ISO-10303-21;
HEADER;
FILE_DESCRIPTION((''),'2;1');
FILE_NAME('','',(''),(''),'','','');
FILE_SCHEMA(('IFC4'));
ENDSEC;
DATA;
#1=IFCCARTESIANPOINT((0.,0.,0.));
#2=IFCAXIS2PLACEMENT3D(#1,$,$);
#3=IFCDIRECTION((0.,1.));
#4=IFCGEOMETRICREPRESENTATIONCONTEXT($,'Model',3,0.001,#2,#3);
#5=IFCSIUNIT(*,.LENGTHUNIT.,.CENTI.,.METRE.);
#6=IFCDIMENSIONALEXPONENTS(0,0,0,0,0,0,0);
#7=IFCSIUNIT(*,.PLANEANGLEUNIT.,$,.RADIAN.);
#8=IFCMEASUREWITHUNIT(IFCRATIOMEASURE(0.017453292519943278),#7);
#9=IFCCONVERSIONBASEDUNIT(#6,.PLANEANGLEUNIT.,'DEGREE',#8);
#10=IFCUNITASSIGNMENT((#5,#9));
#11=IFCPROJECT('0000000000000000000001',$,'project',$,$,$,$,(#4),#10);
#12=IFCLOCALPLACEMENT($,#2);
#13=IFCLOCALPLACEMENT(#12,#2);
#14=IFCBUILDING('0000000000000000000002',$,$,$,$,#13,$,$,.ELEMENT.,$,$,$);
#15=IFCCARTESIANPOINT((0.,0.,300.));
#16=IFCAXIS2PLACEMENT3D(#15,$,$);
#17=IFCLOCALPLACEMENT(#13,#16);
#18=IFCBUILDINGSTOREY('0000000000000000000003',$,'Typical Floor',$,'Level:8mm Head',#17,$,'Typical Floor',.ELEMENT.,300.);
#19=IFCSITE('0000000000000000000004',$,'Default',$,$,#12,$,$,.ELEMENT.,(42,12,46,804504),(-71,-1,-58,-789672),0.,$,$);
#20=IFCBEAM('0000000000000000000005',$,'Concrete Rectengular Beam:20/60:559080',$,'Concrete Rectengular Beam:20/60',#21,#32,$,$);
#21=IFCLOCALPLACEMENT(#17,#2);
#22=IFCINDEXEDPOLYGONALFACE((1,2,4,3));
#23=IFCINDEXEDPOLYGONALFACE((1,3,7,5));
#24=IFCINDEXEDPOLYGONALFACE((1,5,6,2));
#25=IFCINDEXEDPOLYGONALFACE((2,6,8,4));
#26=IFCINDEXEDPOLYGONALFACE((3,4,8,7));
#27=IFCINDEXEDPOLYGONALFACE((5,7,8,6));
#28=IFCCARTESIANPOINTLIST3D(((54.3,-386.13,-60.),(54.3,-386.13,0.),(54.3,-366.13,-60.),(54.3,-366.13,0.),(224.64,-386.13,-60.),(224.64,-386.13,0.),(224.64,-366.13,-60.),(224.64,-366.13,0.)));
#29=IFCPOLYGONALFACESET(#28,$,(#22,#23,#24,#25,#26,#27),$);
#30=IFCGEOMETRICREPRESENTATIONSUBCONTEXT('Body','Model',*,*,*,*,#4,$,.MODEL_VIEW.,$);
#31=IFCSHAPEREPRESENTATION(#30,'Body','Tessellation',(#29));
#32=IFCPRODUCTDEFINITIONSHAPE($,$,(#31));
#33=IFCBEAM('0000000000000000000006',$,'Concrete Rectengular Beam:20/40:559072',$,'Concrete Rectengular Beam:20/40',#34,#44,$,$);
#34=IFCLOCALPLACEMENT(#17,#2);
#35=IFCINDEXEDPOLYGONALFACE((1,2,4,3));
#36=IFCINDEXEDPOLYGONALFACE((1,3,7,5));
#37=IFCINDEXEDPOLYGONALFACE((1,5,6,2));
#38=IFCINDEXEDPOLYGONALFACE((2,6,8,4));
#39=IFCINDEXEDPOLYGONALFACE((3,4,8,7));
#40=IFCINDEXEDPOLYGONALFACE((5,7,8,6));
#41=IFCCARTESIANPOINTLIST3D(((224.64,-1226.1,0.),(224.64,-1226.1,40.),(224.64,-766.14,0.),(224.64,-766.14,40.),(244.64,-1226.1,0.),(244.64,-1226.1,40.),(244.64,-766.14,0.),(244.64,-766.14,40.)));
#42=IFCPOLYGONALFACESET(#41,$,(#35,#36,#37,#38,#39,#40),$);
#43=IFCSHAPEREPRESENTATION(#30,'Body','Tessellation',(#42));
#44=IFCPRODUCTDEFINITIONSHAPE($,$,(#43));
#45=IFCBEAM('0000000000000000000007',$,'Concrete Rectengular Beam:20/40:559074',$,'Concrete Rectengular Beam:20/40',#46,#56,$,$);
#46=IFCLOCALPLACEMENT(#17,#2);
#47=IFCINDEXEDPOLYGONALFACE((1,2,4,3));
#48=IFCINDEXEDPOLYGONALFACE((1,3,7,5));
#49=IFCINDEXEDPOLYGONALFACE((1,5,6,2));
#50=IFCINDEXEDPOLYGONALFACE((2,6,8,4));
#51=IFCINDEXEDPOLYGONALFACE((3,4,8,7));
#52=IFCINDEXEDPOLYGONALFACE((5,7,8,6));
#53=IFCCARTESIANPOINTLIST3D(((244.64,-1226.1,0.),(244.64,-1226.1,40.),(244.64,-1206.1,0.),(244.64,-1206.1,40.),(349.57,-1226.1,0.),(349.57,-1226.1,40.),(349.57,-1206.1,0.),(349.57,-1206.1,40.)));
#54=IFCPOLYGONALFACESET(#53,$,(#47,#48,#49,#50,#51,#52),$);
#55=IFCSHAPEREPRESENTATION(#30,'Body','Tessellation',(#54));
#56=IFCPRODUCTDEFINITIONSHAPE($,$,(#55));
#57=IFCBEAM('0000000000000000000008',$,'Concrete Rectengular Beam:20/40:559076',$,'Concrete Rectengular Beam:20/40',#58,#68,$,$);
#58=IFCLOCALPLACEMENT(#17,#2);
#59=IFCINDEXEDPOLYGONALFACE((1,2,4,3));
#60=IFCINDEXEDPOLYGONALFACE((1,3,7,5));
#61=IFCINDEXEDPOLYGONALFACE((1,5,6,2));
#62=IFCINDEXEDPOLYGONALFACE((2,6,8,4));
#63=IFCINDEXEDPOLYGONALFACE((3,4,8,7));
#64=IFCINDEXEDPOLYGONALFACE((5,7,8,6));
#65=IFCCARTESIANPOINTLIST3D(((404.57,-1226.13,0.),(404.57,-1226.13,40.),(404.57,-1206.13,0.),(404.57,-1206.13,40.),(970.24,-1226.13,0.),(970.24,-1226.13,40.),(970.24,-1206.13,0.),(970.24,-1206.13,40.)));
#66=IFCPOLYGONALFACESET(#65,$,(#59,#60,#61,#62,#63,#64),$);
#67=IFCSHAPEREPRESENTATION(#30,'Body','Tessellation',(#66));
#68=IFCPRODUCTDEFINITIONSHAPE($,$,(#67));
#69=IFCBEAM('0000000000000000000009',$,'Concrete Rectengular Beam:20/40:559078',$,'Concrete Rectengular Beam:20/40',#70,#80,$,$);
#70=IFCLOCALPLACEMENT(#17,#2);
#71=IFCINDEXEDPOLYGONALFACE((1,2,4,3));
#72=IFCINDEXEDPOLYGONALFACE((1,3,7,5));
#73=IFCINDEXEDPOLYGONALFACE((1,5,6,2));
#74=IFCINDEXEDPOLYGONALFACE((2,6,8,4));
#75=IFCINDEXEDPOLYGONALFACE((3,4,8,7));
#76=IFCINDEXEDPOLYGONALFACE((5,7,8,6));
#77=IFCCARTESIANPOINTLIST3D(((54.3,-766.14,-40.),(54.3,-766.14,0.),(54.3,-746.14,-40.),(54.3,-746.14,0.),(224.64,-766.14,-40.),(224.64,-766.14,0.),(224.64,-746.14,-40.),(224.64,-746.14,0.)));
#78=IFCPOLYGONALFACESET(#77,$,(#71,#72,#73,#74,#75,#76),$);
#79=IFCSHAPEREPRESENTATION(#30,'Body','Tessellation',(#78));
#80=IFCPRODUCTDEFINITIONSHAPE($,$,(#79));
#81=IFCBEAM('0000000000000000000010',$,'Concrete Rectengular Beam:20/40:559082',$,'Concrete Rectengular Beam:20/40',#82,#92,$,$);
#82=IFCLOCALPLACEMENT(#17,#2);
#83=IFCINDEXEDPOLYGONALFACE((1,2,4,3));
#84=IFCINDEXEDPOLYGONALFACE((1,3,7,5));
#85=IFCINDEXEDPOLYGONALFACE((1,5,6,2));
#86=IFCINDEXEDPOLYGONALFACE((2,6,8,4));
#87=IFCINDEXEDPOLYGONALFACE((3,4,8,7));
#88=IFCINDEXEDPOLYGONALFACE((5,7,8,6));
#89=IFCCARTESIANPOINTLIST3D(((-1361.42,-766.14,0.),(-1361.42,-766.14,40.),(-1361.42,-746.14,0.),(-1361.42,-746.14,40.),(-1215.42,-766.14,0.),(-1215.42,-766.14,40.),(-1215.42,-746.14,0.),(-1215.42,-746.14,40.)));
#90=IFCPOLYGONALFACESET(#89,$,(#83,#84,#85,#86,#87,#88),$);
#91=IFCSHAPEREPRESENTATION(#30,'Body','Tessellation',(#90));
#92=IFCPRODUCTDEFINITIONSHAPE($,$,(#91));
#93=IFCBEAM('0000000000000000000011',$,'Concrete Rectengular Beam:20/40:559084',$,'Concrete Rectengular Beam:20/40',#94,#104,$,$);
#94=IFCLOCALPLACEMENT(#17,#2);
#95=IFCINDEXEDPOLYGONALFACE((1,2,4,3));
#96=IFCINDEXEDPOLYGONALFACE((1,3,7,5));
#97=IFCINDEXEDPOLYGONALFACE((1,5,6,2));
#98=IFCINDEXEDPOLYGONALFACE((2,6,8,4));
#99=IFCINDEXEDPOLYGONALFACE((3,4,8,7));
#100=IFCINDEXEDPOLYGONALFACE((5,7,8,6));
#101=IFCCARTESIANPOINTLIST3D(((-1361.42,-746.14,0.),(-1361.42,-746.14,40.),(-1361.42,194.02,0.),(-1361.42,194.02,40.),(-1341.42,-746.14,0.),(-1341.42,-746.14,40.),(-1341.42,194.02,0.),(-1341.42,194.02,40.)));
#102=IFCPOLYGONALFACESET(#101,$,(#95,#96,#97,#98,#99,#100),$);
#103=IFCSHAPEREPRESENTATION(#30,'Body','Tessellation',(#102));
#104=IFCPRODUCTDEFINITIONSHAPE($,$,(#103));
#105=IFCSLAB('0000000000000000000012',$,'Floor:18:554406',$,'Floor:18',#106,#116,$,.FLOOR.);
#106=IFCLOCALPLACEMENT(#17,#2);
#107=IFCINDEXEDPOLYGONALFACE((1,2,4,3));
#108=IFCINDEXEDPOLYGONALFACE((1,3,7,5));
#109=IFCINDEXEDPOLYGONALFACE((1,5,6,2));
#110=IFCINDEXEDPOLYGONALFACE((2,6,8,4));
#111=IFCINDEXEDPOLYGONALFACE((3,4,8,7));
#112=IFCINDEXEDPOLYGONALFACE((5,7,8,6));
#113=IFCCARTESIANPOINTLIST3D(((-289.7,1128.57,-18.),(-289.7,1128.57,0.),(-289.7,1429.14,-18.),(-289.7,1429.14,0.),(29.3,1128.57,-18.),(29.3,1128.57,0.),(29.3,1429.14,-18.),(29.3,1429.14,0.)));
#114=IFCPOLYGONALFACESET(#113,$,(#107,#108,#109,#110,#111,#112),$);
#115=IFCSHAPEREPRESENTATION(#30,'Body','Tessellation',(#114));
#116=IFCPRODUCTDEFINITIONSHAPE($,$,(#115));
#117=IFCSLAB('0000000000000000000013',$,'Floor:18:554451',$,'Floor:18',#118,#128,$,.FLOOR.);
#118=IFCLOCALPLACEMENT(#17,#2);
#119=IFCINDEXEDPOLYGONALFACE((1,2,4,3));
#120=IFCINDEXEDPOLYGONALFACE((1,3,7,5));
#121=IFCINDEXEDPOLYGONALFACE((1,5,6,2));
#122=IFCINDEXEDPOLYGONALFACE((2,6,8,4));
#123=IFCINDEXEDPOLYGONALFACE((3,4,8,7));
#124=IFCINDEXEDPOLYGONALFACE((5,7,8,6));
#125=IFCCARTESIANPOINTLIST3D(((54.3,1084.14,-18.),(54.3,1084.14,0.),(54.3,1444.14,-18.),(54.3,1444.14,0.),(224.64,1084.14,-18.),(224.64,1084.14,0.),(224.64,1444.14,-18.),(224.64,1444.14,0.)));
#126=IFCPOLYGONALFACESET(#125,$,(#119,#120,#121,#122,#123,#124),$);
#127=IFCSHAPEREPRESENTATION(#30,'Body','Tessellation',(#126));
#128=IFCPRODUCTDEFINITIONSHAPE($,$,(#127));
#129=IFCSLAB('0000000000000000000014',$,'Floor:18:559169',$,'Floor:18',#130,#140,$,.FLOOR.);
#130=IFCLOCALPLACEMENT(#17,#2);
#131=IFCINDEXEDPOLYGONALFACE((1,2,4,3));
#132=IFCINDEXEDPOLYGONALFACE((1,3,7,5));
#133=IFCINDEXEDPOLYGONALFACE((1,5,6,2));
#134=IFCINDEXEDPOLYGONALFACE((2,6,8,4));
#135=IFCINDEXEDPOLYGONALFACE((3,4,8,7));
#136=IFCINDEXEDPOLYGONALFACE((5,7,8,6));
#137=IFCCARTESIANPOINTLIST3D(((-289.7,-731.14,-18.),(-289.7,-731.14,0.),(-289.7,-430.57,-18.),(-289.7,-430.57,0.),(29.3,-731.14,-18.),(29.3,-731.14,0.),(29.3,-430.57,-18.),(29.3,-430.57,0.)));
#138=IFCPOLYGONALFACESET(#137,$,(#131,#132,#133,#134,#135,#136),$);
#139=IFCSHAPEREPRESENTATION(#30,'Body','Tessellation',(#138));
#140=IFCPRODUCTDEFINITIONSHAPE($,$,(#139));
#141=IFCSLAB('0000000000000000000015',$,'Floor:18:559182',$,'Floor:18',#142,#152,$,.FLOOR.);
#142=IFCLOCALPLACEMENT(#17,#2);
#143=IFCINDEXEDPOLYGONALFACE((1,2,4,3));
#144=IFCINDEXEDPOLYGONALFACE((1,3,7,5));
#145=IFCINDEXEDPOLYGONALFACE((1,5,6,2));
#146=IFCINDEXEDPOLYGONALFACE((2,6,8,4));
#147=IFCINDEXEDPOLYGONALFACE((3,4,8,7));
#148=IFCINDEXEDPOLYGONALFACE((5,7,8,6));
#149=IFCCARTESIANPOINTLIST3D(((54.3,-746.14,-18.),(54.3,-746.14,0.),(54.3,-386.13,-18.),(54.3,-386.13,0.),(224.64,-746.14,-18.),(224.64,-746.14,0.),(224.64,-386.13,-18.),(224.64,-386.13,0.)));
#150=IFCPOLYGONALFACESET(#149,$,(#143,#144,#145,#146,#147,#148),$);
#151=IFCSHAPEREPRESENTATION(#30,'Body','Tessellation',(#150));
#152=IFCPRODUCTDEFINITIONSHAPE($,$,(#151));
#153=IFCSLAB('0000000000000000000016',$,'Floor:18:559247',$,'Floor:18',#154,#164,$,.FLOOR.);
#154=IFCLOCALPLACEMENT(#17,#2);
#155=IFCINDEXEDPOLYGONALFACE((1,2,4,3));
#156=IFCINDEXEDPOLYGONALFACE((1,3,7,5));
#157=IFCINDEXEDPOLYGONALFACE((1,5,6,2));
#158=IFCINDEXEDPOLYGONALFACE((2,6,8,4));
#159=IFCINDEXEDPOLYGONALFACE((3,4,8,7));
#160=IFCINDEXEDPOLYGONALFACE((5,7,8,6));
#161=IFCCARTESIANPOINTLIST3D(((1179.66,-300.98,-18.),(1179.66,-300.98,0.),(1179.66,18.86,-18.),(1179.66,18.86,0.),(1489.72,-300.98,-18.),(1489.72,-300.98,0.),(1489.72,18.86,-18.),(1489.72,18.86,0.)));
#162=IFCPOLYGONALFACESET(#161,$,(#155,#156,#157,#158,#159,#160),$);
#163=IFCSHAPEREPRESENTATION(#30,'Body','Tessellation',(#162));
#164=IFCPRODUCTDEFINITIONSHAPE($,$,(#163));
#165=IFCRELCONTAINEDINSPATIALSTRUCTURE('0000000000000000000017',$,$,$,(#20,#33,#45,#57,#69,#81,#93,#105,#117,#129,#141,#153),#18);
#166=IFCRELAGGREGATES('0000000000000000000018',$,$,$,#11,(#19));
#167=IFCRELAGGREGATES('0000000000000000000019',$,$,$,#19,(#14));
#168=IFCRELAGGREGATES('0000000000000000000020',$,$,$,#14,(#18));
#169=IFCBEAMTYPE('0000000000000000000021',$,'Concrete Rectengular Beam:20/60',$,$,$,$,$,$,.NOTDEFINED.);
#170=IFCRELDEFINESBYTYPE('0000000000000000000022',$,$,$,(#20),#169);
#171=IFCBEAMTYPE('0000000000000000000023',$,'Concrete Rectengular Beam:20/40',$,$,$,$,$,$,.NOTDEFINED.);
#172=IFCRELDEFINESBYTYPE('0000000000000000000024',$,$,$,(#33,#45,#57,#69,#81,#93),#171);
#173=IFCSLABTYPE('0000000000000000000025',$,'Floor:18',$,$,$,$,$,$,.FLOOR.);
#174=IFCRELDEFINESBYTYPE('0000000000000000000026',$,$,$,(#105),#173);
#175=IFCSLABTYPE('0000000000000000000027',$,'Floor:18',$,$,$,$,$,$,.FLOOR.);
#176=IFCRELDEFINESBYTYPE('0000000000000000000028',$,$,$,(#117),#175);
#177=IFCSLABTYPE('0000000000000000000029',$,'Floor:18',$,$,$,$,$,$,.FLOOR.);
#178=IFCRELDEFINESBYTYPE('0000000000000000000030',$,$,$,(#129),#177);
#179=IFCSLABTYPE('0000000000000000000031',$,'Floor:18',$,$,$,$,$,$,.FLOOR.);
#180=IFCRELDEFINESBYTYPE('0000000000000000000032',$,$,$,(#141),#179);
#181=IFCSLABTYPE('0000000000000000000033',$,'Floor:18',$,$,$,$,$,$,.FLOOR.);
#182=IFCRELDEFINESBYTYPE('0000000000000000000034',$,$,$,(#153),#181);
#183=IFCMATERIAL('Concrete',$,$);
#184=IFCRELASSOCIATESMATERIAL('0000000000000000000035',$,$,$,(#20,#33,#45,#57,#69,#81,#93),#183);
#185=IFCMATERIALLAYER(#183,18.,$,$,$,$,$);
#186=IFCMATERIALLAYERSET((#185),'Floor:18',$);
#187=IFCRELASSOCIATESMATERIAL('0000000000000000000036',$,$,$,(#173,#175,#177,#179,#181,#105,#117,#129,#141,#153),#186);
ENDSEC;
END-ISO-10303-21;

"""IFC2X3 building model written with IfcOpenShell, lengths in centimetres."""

from ifc_helpers import new_model, entity, si_unit, converted_unit, direction, frame, frame_2d, origin, place, context, subcontext, project, spatial, rectangle, extrude, material, layer, layer_set, layer_usage, type_object, element, save


model = new_model("IFC2X3")

# Units and contexts
model_context = context("Model", 3, precision=0.001, world=origin(), true_north=direction((0.0, 1.0)))
body_context = subcontext(model_context, "Body", "Model", "MODEL_VIEW")
ifc_project = project(units=[si_unit("LENGTHUNIT", "METRE", prefix="CENTI"), converted_unit("PLANEANGLEUNIT", "DEGREE", entity("IfcRatioMeasure", 0.017453292519943278), si_unit("PLANEANGLEUNIT", "RADIAN"), dimensions=[0, 0, 0, 0, 0, 0, 0])], contexts=[model_context])

# Site, building, storey
site_placement = place(None, origin())
site = spatial("IfcSite", under=ifc_project, at=site_placement, Name="Default", CompositionType="ELEMENT", RefLatitude=(42, 12, 46, 804504), RefLongitude=(-71, -1, -58, -789672), RefElevation=0.0)
building_placement = place(site_placement, origin())
building = spatial("IfcBuilding", under=site, at=building_placement, CompositionType="ELEMENT")
storey_placement = place(building_placement, frame((0.0, 0.0, 300.0)))
storey = spatial("IfcBuildingStorey", under=building, at=storey_placement, Name="Typical Floor", ObjectType="Level:8mm Head", LongName="Typical Floor", CompositionType="ELEMENT", Elevation=300.0)

# Beams
ifc_material = material(Name="Concrete")
beam_type_1 = type_object("IfcBeamType", Name="Concrete Rectengular Beam:20/60", PredefinedType="NOTDEFINED")
beam_1_placement = place(storey_placement, frame((234.64, -376.13, 0.0), z_axis=(0.0, 0.0, 1.0), x_axis=(-1.0, 0.0, 0.0)))
element("IfcBeam", 1, at=beam_1_placement, inside=storey, type_object=beam_type_1, material=ifc_material, Name="Concrete Rectengular Beam:20/60:559080", ObjectType="Concrete Rectengular Beam:20/60", context=body_context, shape_type="SweptSolid", body=[
    extrude(rectangle(XDim=60.0, YDim=20.0, at=frame_2d((0.0, 0.0), x_axis=(1.0, 0.0))), frame((10.0, 0.0, -30.0), z_axis=(1.0, 0.0, 0.0), x_axis=(0.0, 0.0, -1.0)), (0.0, 0.0, 1.0), 170.35),
])
beam_type_2 = type_object("IfcBeamType", Name="Concrete Rectengular Beam:20/40", PredefinedType="NOTDEFINED")
beam_2_placement = place(storey_placement, frame((234.64, -766.14, 0.0), z_axis=(0.0, 0.0, 1.0), x_axis=(0.0, -1.0, 0.0)))
element("IfcBeam", 2, at=beam_2_placement, inside=storey, type_object=beam_type_2, material=ifc_material, Name="Concrete Rectengular Beam:20/40:559072", ObjectType="Concrete Rectengular Beam:20/40", context=body_context, shape_type="SweptSolid", body=[
    extrude(rectangle(XDim=40.0, YDim=20.0, at=frame_2d((0.0, 0.0), x_axis=(1.0, 0.0))), frame((0.0, 0.0, 20.0), z_axis=(1.0, 0.0, 0.0), x_axis=(0.0, 0.0, -1.0)), (0.0, 0.0, 1.0), 459.96),
])
beam_3_placement = place(storey_placement, frame((234.64, -1216.1, 0.0)))
element("IfcBeam", 3, at=beam_3_placement, inside=storey, type_object=beam_type_2, material=ifc_material, Name="Concrete Rectengular Beam:20/40:559074", ObjectType="Concrete Rectengular Beam:20/40", context=body_context, shape_type="SweptSolid", body=[
    extrude(rectangle(XDim=40.0, YDim=20.0, at=frame_2d((0.0, 0.0), x_axis=(1.0, 0.0))), frame((10.0, 0.0, 20.0), z_axis=(1.0, 0.0, 0.0), x_axis=(0.0, 0.0, -1.0)), (0.0, 0.0, 1.0), 104.93),
])
beam_4_placement = place(storey_placement, frame((404.57, -1216.13, 0.0)))
element("IfcBeam", 4, at=beam_4_placement, inside=storey, type_object=beam_type_2, material=ifc_material, Name="Concrete Rectengular Beam:20/40:559076", ObjectType="Concrete Rectengular Beam:20/40", context=body_context, shape_type="SweptSolid", body=[
    extrude(rectangle(XDim=40.0, YDim=20.0, at=frame_2d((0.0, 0.0), x_axis=(1.0, 0.0))), frame((0.0, 0.0, 20.0), z_axis=(1.0, 0.0, 0.0), x_axis=(0.0, 0.0, -1.0)), (0.0, 0.0, 1.0), 565.67),
])
beam_5_placement = place(storey_placement, frame((234.64, -756.14, 0.0), z_axis=(0.0, 0.0, 1.0), x_axis=(-1.0, 0.0, 0.0)))
element("IfcBeam", 5, at=beam_5_placement, inside=storey, type_object=beam_type_2, material=ifc_material, Name="Concrete Rectengular Beam:20/40:559078", ObjectType="Concrete Rectengular Beam:20/40", context=body_context, shape_type="SweptSolid", body=[
    extrude(rectangle(XDim=40.0, YDim=20.0, at=frame_2d((0.0, 0.0), x_axis=(1.0, 0.0))), frame((10.0, 0.0, -20.0), z_axis=(1.0, 0.0, 0.0), x_axis=(0.0, 0.0, -1.0)), (0.0, 0.0, 1.0), 170.35),
])
beam_6_placement = place(storey_placement, frame((-1215.42, -756.14, 0.0), z_axis=(0.0, 0.0, 1.0), x_axis=(-1.0, 0.0, 0.0)))
element("IfcBeam", 6, at=beam_6_placement, inside=storey, type_object=beam_type_2, material=ifc_material, Name="Concrete Rectengular Beam:20/40:559082", ObjectType="Concrete Rectengular Beam:20/40", context=body_context, shape_type="SweptSolid", body=[
    extrude(rectangle(XDim=40.0, YDim=20.0, at=frame_2d((0.0, 0.0), x_axis=(1.0, 0.0))), frame((0.0, 0.0, 20.0), z_axis=(1.0, 0.0, 0.0), x_axis=(0.0, 0.0, -1.0)), (0.0, 0.0, 1.0), 146.0),
])
beam_7_placement = place(storey_placement, frame((-1351.42, -756.14, 0.0), z_axis=(0.0, 0.0, 1.0), x_axis=(0.0, 1.0, 0.0)))
element("IfcBeam", 7, at=beam_7_placement, inside=storey, type_object=beam_type_2, material=ifc_material, Name="Concrete Rectengular Beam:20/40:559084", ObjectType="Concrete Rectengular Beam:20/40", context=body_context, shape_type="SweptSolid", body=[
    extrude(rectangle(XDim=40.0, YDim=20.0, at=frame_2d((0.0, 0.0), x_axis=(1.0, 0.0))), frame((10.0, 0.0, 20.0), z_axis=(1.0, 0.0, 0.0), x_axis=(0.0, 0.0, -1.0)), (0.0, 0.0, 1.0), 940.16),
])

# Slabs
ifc_layer_1 = layer(ifc_material, 18.0)
ifc_layer_set_1 = layer_set([ifc_layer_1], Name="Floor:18")
ifc_layer_usage_1 = layer_usage(ifc_layer_set_1, "AXIS3", "POSITIVE", 0.0)
slab_type_1 = type_object("IfcSlabType", Name="Floor:18", PredefinedType="FLOOR", material=ifc_layer_set_1)
slab_1_placement = place(storey_placement, origin())
element("IfcSlab", 8, at=slab_1_placement, inside=storey, type_object=slab_type_1, material=ifc_layer_usage_1, Name="Floor:18:554406", ObjectType="Floor:18", PredefinedType="FLOOR", context=body_context, shape_type="SweptSolid", body=[
    extrude(rectangle(XDim=300.57, YDim=319.0, at=frame_2d((0.0, 0.0), x_axis=(1.0, 0.0))), frame((-130.2, 1278.86, 0.0), z_axis=(0.0, 0.0, -1.0), x_axis=(0.0, 1.0, 0.0)), (0.0, 0.0, 1.0), 18.0),
])
ifc_layer_usage_2 = layer_usage(ifc_layer_set_1, "AXIS3", "POSITIVE", 0.0)
slab_type_2 = type_object("IfcSlabType", Name="Floor:18", PredefinedType="FLOOR", material=ifc_layer_set_1)
slab_2_placement = place(storey_placement, origin())
element("IfcSlab", 9, at=slab_2_placement, inside=storey, type_object=slab_type_2, material=ifc_layer_usage_2, Name="Floor:18:554451", ObjectType="Floor:18", PredefinedType="FLOOR", context=body_context, shape_type="SweptSolid", body=[
    extrude(rectangle(XDim=360.01, YDim=170.35, at=frame_2d((0.0, 0.0), x_axis=(1.0, 0.0))), frame((139.47, 1264.14, 0.0), z_axis=(0.0, 0.0, -1.0), x_axis=(0.0, 1.0, 0.0)), (0.0, 0.0, 1.0), 18.0),
])
ifc_layer_usage_3 = layer_usage(ifc_layer_set_1, "AXIS3", "POSITIVE", 0.0)
slab_type_3 = type_object("IfcSlabType", Name="Floor:18", PredefinedType="FLOOR", material=ifc_layer_set_1)
slab_3_placement = place(storey_placement, origin())
element("IfcSlab", 10, at=slab_3_placement, inside=storey, type_object=slab_type_3, material=ifc_layer_usage_3, Name="Floor:18:559169", ObjectType="Floor:18", PredefinedType="FLOOR", context=body_context, shape_type="SweptSolid", body=[
    extrude(rectangle(XDim=300.57, YDim=319.0, at=frame_2d((0.0, 0.0), x_axis=(1.0, 0.0))), frame((-130.2, -580.85, 0.0), z_axis=(0.0, 0.0, -1.0), x_axis=(0.0, 1.0, 0.0)), (0.0, 0.0, 1.0), 18.0),
])
ifc_layer_usage_4 = layer_usage(ifc_layer_set_1, "AXIS3", "POSITIVE", 0.0)
slab_type_4 = type_object("IfcSlabType", Name="Floor:18", PredefinedType="FLOOR", material=ifc_layer_set_1)
slab_4_placement = place(storey_placement, origin())
element("IfcSlab", 11, at=slab_4_placement, inside=storey, type_object=slab_type_4, material=ifc_layer_usage_4, Name="Floor:18:559182", ObjectType="Floor:18", PredefinedType="FLOOR", context=body_context, shape_type="SweptSolid", body=[
    extrude(rectangle(XDim=360.01, YDim=170.35, at=frame_2d((0.0, 0.0), x_axis=(1.0, 0.0))), frame((139.47, -566.14, 0.0), z_axis=(0.0, 0.0, -1.0), x_axis=(0.0, 1.0, 0.0)), (0.0, 0.0, 1.0), 18.0),
])
ifc_layer_usage_5 = layer_usage(ifc_layer_set_1, "AXIS3", "POSITIVE", 0.0)
slab_type_5 = type_object("IfcSlabType", Name="Floor:18", PredefinedType="FLOOR", material=ifc_layer_set_1)
slab_5_placement = place(storey_placement, origin())
element("IfcSlab", 12, at=slab_5_placement, inside=storey, type_object=slab_type_5, material=ifc_layer_usage_5, Name="Floor:18:559247", ObjectType="Floor:18", PredefinedType="FLOOR", context=body_context, shape_type="SweptSolid", body=[
    extrude(rectangle(XDim=319.84, YDim=310.06, at=frame_2d((0.0, 0.0), x_axis=(1.0, 0.0))), frame((1334.69, -141.06, 0.0), z_axis=(0.0, 0.0, -1.0), x_axis=(0.0, 1.0, 0.0)), (0.0, 0.0, 1.0), 18.0),
])

save(model, "model.ifc")
